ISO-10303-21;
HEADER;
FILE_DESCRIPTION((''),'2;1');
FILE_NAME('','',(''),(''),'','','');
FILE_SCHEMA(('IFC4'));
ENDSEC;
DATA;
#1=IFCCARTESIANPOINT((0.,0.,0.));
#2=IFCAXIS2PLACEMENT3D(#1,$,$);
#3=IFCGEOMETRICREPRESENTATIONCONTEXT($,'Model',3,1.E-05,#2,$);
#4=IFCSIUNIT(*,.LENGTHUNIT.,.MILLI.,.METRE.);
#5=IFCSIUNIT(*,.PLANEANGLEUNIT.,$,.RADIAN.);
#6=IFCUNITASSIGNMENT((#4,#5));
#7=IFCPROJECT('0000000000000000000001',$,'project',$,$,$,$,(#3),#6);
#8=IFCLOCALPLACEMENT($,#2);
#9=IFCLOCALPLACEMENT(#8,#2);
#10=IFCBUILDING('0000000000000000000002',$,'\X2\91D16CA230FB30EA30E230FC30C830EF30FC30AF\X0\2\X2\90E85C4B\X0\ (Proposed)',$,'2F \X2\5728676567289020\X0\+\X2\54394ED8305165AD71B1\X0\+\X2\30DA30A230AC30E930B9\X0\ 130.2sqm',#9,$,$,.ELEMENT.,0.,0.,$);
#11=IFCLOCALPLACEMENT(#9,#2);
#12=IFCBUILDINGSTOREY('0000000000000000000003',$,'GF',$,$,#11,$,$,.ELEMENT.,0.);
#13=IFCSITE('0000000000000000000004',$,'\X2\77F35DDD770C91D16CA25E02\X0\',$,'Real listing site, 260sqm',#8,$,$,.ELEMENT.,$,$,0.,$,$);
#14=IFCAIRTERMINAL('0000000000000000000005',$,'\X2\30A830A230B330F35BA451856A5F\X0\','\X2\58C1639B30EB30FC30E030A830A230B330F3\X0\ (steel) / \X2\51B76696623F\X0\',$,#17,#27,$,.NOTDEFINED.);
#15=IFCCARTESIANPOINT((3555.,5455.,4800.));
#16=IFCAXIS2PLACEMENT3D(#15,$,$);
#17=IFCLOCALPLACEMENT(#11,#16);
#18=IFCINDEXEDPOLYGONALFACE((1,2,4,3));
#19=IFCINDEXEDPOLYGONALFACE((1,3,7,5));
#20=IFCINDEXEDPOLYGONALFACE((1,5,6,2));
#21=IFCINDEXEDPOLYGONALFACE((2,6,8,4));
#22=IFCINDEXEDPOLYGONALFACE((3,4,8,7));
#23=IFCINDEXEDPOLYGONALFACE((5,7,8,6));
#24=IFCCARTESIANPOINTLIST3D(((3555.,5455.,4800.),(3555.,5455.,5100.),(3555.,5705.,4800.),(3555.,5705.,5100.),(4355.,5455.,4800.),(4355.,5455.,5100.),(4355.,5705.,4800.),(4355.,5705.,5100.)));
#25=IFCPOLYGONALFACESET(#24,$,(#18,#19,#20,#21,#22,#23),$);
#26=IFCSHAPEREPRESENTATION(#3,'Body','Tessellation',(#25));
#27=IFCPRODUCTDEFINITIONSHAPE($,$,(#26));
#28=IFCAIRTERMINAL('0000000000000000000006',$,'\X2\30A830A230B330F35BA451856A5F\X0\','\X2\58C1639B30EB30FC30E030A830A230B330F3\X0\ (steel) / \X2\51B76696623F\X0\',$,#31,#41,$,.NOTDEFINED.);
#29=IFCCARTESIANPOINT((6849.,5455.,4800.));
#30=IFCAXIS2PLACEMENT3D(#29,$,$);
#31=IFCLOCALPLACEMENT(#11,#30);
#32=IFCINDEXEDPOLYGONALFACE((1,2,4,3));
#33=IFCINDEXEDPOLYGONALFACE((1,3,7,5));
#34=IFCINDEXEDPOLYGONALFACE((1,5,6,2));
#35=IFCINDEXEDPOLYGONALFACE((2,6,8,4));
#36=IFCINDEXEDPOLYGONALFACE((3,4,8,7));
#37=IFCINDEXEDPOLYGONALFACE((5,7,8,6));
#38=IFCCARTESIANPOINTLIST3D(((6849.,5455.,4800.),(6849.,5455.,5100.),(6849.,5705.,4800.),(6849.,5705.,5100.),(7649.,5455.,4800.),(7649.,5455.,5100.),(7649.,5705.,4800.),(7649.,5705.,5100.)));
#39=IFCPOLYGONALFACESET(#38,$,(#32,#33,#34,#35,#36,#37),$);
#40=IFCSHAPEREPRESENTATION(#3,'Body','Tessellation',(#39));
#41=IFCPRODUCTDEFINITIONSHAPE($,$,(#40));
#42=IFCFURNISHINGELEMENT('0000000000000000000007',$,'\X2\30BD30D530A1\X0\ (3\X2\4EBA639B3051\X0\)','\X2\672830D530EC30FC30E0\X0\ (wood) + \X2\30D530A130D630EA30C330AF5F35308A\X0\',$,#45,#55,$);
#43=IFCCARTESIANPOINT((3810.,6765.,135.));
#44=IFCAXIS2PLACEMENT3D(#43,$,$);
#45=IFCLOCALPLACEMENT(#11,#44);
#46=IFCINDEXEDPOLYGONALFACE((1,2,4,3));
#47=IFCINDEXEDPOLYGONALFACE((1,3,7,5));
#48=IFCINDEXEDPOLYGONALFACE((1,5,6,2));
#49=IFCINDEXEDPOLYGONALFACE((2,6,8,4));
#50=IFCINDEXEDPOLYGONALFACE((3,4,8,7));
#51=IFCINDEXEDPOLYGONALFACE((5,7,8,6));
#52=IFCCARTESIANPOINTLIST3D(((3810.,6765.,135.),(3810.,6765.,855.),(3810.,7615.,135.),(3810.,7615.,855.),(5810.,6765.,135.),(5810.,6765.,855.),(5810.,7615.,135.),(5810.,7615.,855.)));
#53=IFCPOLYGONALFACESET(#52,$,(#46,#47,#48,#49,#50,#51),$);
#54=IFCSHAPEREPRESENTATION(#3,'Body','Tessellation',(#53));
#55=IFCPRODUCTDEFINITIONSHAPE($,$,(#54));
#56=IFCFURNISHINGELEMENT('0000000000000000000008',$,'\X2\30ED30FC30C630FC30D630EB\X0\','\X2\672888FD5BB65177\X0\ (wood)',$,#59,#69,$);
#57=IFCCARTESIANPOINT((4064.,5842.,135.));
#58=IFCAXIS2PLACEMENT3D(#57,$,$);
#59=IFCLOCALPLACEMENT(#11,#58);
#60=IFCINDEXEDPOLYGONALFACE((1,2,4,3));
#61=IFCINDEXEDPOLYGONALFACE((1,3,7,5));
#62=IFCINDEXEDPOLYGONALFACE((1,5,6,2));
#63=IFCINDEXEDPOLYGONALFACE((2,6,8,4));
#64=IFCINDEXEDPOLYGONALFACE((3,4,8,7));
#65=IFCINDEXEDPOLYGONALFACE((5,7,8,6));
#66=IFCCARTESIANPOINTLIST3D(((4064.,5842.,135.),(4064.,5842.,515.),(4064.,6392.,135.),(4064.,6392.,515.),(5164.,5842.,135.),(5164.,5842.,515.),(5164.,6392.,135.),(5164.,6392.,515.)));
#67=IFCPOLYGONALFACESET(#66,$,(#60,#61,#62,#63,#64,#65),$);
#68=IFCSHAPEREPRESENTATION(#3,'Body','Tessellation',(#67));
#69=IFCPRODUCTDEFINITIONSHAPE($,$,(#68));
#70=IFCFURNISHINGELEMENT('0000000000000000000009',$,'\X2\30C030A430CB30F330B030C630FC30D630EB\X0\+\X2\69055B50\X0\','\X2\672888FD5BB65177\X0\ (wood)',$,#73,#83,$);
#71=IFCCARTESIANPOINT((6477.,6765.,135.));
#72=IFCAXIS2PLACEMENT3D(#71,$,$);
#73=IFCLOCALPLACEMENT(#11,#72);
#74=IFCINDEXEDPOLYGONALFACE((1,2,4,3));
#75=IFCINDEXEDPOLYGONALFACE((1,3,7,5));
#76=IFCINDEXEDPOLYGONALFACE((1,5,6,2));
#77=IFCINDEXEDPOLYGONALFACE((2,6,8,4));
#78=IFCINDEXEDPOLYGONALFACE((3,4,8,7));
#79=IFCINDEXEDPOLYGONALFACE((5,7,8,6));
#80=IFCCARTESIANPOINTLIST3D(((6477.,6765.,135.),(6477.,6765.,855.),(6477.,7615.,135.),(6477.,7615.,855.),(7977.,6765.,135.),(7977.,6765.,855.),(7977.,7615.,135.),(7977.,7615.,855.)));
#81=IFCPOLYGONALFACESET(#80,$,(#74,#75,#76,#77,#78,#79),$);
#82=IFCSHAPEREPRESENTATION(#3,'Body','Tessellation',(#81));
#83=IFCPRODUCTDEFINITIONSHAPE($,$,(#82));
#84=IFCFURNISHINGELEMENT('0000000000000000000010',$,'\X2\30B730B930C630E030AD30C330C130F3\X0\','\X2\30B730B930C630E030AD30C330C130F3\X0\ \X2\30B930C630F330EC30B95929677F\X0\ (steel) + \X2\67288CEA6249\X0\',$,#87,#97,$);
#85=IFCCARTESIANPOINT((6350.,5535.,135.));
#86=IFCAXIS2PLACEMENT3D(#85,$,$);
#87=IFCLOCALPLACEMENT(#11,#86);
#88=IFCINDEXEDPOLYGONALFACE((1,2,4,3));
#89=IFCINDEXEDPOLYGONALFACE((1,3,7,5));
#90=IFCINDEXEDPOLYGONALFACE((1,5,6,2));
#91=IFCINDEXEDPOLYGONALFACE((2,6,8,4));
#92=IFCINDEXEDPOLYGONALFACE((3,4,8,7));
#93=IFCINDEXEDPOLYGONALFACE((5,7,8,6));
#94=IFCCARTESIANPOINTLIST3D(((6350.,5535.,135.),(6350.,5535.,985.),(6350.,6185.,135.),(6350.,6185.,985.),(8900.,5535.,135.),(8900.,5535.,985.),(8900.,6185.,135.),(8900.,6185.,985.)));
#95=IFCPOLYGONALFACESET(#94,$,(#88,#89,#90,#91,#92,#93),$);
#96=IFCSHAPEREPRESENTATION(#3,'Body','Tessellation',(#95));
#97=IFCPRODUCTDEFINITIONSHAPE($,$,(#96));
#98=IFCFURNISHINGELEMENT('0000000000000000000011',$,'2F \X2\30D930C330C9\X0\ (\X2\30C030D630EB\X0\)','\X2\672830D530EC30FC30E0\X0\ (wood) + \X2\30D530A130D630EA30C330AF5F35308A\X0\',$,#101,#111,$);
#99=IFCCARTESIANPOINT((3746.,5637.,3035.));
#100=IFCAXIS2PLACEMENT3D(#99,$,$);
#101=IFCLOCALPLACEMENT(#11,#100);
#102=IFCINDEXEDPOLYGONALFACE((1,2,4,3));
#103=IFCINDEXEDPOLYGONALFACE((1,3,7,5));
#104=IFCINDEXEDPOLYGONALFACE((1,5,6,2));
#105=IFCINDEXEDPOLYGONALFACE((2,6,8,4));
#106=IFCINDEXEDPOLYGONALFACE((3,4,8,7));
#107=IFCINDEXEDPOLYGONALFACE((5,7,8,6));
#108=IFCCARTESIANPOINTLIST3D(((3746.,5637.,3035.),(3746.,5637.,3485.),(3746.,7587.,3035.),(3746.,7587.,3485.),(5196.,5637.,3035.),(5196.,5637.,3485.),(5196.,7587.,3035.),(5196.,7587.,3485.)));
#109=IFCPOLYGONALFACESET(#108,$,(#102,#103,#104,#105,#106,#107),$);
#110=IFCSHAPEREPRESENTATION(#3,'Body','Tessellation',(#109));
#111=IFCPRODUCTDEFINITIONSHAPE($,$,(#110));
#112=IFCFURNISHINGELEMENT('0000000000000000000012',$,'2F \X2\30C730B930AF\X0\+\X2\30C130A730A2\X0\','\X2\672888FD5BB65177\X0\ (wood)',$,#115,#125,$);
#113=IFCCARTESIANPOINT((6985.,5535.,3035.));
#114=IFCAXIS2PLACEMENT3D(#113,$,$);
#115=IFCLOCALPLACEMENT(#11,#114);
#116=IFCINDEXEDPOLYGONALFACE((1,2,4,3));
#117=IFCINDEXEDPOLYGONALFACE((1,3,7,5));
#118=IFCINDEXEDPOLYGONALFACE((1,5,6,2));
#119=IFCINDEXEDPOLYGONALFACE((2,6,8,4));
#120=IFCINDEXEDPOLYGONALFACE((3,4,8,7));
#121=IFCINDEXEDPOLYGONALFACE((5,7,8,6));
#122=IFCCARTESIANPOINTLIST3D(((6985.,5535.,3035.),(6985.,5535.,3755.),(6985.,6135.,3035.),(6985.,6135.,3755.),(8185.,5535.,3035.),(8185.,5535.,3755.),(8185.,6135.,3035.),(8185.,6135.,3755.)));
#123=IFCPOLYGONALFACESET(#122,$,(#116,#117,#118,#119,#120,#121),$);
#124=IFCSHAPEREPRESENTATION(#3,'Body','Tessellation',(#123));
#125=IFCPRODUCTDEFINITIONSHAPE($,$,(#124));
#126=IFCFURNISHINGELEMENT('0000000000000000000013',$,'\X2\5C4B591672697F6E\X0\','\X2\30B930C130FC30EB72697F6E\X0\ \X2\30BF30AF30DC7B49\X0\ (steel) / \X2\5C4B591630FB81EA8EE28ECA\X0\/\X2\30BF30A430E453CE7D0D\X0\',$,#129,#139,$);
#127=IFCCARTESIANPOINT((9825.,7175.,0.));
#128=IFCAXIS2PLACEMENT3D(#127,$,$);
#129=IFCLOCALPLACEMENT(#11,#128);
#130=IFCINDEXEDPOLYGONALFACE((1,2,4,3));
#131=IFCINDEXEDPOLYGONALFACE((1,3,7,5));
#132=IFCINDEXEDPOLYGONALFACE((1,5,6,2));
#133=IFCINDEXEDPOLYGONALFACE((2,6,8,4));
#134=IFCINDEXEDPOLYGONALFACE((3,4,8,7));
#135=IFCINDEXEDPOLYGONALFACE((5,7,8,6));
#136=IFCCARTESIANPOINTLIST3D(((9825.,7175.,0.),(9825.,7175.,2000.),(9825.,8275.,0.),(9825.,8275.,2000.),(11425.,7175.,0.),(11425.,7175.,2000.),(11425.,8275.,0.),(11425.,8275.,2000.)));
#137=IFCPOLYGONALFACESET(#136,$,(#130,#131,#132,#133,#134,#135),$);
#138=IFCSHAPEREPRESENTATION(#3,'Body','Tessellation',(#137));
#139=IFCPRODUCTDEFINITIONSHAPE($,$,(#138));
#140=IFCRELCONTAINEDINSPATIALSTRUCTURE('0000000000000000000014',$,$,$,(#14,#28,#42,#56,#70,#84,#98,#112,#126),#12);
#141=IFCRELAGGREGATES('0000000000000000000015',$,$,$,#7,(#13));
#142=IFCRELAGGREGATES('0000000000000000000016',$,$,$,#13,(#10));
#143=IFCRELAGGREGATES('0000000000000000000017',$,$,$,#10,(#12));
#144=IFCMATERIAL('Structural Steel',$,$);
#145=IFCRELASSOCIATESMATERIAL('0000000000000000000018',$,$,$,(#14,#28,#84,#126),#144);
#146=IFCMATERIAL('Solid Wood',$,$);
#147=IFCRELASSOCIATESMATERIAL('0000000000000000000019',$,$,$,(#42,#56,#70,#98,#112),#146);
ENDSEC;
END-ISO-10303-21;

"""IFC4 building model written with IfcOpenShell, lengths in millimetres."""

from ifc_helpers import new_model, si_unit, frame, frame_2d, origin, place, context, project, spatial, rectangle, extrude, material, element, save


model = new_model("IFC4")

# Units and contexts
model_context = context("Model", 3, precision=1e-05, world=origin())
ifc_project = project(units=[si_unit("LENGTHUNIT", "METRE", prefix="MILLI"), si_unit("PLANEANGLEUNIT", "RADIAN")], contexts=[model_context])

# Site, building, storey
site_placement = place(None, origin())
site = spatial("IfcSite", under=ifc_project, at=site_placement, Name="石川県金沢市", ObjectType="Real listing site, 260sqm", CompositionType="ELEMENT", RefElevation=0.0)
building_placement = place(site_placement, origin())
building = spatial("IfcBuilding", under=site, at=building_placement, Name="金沢・リモートワーク2部屋 (Proposed)", ObjectType="2F 在来木造+吹付け断熱+ペアガラス 130.2sqm", CompositionType="ELEMENT", ElevationOfRefHeight=0.0, ElevationOfTerrain=0.0)
storey_placement = place(building_placement, origin())
storey = spatial("IfcBuildingStorey", under=building, at=storey_placement, Name="GF", CompositionType="ELEMENT", Elevation=0.0)

# Shared definitions
ifc_material_1 = material(Name="Solid Wood")

# Shared definitions
ifc_material_2 = material(Name="Structural Steel")

# Air terminals
air_terminal_1_placement = place(storey_placement, frame((3555.0, 5455.0, 4800.0)))
element("IfcAirTerminal", 1, at=air_terminal_1_placement, inside=storey, material=ifc_material_2, Name="エアコン室内機", Description="壁掛ルームエアコン (steel) / 冷暖房", PredefinedType="NOTDEFINED", context=model_context, shape_type="SweptSolid", body=[
    extrude(rectangle(XDim=800.0, YDim=250.0, at=frame_2d((400.0, 125.0))), frame((3555.0, 5455.0, 4800.0)), (0.0, 0.0, 1.0), 300.0),
])
air_terminal_2_placement = place(storey_placement, frame((6849.0, 5455.0, 4800.0)))
element("IfcAirTerminal", 2, at=air_terminal_2_placement, inside=storey, material=ifc_material_2, Name="エアコン室内機", Description="壁掛ルームエアコン (steel) / 冷暖房", PredefinedType="NOTDEFINED", context=model_context, shape_type="SweptSolid", body=[
    extrude(rectangle(XDim=800.0, YDim=250.0, at=frame_2d((400.0, 125.0))), frame((6849.0, 5455.0, 4800.0)), (0.0, 0.0, 1.0), 300.0),
])

# Furnishing elements
furnishing_1_placement = place(storey_placement, frame((3810.0, 6765.0, 135.0)))
element("IfcFurnishingElement", 3, at=furnishing_1_placement, inside=storey, material=ifc_material_1, Name="ソファ (3人掛け)", Description="木フレーム (wood) + ファブリック張り", context=model_context, shape_type="SweptSolid", body=[
    extrude(rectangle(XDim=2000.0, YDim=850.0, at=frame_2d((1000.0, 425.0))), frame((3810.0, 6765.0, 135.0)), (0.0, 0.0, 1.0), 720.0),
])
furnishing_2_placement = place(storey_placement, frame((4064.0, 5842.0, 135.0)))
element("IfcFurnishingElement", 4, at=furnishing_2_placement, inside=storey, material=ifc_material_1, Name="ローテーブル", Description="木製家具 (wood)", context=model_context, shape_type="SweptSolid", body=[
    extrude(rectangle(XDim=1100.0, YDim=550.0, at=frame_2d((550.0, 275.0))), frame((4064.0, 5842.0, 135.0)), (0.0, 0.0, 1.0), 380.0),
])
furnishing_3_placement = place(storey_placement, frame((6477.0, 6765.0, 135.0)))
element("IfcFurnishingElement", 5, at=furnishing_3_placement, inside=storey, material=ifc_material_1, Name="ダイニングテーブル+椅子", Description="木製家具 (wood)", context=model_context, shape_type="SweptSolid", body=[
    extrude(rectangle(XDim=1500.0, YDim=850.0, at=frame_2d((750.0, 425.0))), frame((6477.0, 6765.0, 135.0)), (0.0, 0.0, 1.0), 720.0),
])
furnishing_4_placement = place(storey_placement, frame((6350.0, 5535.0, 135.0)))
element("IfcFurnishingElement", 6, at=furnishing_4_placement, inside=storey, material=ifc_material_2, Name="システムキッチン", Description="システムキッチン ステンレス天板 (steel) + 木質扉", context=model_context, shape_type="SweptSolid", body=[
    extrude(rectangle(XDim=2550.0, YDim=650.0, at=frame_2d((1275.0, 325.0))), frame((6350.0, 5535.0, 135.0)), (0.0, 0.0, 1.0), 850.0),
])
furnishing_5_placement = place(storey_placement, frame((3746.0, 5637.0, 3035.0)))
element("IfcFurnishingElement", 7, at=furnishing_5_placement, inside=storey, material=ifc_material_1, Name="2F ベッド (ダブル)", Description="木フレーム (wood) + ファブリック張り", context=model_context, shape_type="SweptSolid", body=[
    extrude(rectangle(XDim=1450.0, YDim=1950.0, at=frame_2d((725.0, 975.0))), frame((3746.0, 5637.0, 3035.0)), (0.0, 0.0, 1.0), 450.0),
])
furnishing_6_placement = place(storey_placement, frame((6985.0, 5535.0, 3035.0)))
element("IfcFurnishingElement", 8, at=furnishing_6_placement, inside=storey, material=ifc_material_1, Name="2F デスク+チェア", Description="木製家具 (wood)", context=model_context, shape_type="SweptSolid", body=[
    extrude(rectangle(XDim=1200.0, YDim=600.0, at=frame_2d((600.0, 300.0))), frame((6985.0, 5535.0, 3035.0)), (0.0, 0.0, 1.0), 720.0),
])
furnishing_7_placement = place(storey_placement, frame((9825.0, 7175.0, 0.0)))
element("IfcFurnishingElement", 9, at=furnishing_7_placement, inside=storey, material=ifc_material_2, Name="屋外物置", Description="スチール物置 タクボ等 (steel) / 屋外・自転車/タイヤ収納", context=model_context, shape_type="SweptSolid", body=[
    extrude(rectangle(XDim=1600.0, YDim=1100.0, at=frame_2d((800.0, 550.0))), frame((9825.0, 7175.0, 0.0)), (0.0, 0.0, 1.0), 2000.0),
])

save(model, "model.ifc")
